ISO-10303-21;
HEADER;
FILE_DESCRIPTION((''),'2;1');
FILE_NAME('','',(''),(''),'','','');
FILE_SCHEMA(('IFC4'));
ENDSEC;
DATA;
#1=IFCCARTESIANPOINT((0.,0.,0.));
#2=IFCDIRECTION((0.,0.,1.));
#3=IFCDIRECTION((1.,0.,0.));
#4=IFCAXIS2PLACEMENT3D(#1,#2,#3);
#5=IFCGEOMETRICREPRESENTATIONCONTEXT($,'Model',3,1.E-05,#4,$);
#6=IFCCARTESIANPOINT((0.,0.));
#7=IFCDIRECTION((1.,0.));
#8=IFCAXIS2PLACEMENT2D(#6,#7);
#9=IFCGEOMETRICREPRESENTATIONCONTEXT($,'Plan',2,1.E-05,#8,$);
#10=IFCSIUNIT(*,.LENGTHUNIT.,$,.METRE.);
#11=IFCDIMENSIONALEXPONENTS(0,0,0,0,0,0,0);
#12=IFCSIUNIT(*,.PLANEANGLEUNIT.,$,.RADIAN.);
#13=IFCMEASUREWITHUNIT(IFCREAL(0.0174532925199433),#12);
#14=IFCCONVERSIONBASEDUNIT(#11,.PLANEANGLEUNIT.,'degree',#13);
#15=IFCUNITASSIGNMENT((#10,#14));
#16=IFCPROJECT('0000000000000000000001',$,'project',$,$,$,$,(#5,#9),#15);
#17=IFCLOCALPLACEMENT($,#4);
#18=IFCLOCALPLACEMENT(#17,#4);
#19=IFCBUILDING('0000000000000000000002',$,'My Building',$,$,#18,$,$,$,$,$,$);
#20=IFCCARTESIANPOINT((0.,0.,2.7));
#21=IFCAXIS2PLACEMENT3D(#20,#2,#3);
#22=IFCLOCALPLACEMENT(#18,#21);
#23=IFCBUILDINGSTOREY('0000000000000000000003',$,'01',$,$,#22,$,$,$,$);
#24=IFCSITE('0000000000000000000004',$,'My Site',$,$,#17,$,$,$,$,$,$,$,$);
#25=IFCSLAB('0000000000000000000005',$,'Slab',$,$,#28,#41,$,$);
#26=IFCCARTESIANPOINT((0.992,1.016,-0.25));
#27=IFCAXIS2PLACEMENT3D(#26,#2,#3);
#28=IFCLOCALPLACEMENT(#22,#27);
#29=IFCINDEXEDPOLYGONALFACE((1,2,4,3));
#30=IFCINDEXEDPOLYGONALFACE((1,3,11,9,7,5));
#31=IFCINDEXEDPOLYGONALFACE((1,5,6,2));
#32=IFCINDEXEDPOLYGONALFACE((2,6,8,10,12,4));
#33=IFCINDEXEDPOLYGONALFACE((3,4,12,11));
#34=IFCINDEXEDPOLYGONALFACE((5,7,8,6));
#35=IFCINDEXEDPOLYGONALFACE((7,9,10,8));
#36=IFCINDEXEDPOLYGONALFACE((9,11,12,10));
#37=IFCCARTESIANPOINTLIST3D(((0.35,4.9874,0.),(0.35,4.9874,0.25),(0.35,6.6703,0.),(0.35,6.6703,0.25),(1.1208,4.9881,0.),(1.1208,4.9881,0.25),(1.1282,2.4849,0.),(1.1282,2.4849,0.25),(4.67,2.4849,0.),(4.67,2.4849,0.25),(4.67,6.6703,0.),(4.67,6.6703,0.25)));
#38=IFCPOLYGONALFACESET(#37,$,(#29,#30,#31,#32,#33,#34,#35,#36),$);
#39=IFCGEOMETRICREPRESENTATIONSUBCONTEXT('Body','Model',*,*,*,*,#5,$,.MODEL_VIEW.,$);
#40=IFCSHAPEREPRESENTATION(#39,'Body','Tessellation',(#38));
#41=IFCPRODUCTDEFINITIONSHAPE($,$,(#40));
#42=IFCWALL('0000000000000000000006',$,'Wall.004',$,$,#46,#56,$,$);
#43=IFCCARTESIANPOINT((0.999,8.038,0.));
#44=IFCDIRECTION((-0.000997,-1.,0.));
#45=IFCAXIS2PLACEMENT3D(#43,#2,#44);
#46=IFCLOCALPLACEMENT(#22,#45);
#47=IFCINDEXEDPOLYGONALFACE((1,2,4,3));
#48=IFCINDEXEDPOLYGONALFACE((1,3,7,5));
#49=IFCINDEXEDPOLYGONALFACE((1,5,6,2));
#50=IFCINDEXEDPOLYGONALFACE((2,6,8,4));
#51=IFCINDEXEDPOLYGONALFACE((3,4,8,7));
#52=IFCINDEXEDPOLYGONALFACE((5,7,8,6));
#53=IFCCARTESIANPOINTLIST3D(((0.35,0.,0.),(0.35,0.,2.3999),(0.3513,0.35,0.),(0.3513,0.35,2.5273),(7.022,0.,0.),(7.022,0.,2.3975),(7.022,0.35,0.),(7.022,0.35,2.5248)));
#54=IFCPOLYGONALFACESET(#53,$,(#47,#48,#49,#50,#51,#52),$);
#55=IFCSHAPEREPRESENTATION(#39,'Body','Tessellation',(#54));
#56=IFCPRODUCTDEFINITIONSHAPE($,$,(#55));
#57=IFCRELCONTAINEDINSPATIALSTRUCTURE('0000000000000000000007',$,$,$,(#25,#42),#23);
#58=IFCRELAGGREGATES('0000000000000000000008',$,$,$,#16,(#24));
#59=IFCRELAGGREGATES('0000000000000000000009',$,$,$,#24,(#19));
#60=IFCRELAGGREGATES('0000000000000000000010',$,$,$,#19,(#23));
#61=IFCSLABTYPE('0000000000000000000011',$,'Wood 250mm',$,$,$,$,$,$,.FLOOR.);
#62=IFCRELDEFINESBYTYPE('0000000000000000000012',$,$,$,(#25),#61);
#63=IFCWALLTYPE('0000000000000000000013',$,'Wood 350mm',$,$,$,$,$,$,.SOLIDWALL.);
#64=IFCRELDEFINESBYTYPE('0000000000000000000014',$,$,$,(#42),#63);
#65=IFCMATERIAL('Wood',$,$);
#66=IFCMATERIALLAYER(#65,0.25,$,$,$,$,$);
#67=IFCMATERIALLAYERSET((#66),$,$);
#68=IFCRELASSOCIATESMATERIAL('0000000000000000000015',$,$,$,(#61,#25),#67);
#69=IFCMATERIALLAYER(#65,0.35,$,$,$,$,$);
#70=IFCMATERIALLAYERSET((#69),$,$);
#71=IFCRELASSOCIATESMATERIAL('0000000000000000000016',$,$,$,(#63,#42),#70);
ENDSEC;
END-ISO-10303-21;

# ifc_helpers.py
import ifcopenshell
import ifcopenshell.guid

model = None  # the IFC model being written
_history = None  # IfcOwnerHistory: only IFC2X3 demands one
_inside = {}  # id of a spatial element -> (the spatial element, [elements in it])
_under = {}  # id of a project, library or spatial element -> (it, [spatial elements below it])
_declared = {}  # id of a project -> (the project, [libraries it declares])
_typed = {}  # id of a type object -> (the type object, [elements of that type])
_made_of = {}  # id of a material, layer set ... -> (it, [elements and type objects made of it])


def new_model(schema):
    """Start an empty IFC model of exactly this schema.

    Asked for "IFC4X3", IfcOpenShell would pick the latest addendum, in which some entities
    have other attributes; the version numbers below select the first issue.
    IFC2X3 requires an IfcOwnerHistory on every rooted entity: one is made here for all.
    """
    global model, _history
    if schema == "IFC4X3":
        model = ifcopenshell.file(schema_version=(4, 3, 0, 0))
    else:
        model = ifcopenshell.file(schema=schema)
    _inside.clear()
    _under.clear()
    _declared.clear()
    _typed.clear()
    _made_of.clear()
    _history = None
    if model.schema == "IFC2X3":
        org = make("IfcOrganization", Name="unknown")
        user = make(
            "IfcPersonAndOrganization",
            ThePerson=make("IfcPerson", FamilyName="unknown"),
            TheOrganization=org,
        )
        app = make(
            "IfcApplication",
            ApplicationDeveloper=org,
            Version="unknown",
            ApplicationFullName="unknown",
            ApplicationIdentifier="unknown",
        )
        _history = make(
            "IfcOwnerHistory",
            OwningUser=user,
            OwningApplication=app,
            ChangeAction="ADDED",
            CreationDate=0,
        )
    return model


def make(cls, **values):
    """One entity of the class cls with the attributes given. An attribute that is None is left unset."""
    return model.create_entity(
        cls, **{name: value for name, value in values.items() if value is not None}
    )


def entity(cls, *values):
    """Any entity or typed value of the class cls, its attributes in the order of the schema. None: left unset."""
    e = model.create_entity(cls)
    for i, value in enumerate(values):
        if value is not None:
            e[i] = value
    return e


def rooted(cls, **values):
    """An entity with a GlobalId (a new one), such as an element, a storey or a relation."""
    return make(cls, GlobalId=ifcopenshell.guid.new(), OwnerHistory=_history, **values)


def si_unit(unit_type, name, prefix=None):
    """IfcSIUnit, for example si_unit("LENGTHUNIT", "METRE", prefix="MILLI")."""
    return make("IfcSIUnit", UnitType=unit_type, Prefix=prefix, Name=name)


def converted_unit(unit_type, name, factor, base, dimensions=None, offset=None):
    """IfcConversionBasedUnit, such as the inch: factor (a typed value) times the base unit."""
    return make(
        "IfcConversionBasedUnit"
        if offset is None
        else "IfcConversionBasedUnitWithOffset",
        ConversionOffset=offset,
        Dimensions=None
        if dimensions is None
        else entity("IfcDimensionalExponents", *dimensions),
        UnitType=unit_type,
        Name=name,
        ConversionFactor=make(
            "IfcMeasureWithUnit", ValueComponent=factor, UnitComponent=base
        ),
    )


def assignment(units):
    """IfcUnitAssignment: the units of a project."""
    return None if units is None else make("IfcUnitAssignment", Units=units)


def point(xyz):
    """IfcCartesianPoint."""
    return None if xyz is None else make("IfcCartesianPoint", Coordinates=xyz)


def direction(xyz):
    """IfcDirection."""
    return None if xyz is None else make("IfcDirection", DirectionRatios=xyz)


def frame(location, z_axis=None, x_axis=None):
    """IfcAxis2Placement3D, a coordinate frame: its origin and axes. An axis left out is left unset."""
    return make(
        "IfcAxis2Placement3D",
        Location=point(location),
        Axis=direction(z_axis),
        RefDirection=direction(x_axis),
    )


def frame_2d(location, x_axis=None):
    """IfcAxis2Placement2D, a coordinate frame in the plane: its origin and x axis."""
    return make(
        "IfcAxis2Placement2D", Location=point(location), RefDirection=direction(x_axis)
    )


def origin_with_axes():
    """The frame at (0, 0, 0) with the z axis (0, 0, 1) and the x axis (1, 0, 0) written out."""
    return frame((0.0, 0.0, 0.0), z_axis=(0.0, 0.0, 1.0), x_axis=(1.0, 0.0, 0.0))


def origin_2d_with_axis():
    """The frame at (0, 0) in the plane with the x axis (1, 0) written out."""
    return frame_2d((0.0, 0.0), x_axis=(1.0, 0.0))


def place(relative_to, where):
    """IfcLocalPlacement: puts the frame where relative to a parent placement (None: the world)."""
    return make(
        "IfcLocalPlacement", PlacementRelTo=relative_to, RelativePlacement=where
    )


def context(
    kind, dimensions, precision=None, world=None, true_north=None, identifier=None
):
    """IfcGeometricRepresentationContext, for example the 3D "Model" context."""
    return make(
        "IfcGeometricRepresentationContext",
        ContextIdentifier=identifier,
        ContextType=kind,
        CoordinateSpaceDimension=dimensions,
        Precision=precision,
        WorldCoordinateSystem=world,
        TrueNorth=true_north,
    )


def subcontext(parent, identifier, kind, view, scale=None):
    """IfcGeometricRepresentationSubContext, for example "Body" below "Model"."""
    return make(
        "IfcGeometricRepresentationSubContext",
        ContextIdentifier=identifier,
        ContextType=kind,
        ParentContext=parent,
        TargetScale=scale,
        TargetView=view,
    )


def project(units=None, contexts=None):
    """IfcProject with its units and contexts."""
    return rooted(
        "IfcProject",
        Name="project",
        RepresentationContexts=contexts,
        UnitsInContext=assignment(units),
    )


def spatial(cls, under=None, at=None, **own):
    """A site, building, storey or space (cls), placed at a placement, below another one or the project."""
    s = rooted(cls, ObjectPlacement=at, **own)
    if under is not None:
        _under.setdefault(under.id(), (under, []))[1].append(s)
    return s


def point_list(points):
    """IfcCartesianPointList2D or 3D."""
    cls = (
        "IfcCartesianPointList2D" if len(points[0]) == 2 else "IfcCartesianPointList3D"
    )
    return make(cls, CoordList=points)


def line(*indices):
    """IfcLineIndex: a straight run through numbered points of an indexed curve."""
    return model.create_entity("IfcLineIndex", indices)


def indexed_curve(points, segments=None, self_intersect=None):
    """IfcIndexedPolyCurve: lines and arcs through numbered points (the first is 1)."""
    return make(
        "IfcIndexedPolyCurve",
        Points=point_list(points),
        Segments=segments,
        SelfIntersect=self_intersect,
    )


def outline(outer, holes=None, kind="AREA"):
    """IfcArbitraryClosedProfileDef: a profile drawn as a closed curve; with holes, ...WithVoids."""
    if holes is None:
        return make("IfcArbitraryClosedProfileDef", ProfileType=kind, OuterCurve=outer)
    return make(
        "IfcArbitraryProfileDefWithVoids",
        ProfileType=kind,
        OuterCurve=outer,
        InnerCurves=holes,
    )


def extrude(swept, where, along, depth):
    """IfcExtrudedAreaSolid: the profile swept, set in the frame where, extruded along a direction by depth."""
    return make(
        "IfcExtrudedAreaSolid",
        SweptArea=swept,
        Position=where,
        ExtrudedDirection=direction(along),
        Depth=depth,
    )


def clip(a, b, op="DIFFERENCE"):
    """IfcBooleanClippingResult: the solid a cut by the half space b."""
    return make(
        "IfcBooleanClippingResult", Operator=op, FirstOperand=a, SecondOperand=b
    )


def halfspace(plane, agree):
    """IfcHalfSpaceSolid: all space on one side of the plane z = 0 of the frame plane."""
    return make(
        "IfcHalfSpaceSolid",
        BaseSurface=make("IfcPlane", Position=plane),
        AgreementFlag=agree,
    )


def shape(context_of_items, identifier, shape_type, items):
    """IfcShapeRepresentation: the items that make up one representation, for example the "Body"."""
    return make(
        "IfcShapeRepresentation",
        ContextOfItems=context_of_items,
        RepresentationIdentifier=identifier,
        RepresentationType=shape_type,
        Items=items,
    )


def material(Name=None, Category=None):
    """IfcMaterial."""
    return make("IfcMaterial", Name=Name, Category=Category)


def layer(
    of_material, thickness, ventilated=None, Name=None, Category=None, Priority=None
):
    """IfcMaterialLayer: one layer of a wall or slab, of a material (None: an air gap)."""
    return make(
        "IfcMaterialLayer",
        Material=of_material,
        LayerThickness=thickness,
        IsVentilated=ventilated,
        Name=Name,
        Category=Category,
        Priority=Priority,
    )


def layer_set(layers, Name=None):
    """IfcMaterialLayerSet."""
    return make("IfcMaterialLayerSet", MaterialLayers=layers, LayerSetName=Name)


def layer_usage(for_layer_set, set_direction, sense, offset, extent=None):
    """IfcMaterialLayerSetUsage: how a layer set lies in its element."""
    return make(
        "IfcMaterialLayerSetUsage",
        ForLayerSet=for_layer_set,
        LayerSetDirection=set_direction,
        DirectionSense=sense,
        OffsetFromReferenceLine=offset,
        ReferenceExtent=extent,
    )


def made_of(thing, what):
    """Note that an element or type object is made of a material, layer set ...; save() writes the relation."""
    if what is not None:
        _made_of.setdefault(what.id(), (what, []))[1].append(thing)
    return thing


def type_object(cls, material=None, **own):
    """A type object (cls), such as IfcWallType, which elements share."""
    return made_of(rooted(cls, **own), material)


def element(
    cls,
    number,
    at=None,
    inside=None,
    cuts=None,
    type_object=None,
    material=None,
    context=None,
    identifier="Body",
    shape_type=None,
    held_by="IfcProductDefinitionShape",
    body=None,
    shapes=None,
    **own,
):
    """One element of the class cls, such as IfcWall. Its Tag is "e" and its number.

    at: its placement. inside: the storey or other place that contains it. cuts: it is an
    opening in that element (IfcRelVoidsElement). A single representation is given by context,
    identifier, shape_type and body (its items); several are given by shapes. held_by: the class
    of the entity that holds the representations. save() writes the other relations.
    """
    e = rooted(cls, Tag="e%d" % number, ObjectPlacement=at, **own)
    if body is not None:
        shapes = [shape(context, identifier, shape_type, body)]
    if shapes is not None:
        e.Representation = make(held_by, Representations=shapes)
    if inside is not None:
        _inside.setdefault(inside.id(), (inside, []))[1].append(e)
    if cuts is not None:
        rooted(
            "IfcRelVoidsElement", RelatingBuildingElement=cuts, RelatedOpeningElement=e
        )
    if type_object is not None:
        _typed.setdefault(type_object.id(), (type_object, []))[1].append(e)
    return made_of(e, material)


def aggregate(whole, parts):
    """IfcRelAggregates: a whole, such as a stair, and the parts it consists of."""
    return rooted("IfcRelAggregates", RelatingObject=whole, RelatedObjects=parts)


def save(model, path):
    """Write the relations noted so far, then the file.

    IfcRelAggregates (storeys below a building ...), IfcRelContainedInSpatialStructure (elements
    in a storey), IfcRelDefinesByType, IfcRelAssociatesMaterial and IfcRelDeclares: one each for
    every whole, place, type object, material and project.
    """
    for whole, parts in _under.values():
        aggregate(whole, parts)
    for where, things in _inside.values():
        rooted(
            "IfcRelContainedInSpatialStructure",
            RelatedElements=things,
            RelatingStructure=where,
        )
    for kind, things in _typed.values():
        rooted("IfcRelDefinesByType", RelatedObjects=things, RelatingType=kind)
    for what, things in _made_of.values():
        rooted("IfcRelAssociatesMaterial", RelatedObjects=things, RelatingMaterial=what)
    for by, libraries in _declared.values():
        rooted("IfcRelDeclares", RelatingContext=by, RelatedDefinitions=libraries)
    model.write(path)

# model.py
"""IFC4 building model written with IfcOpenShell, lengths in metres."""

from ifc_helpers import new_model, entity, si_unit, converted_unit, frame, origin_with_axes, origin_2d_with_axis, place, context, subcontext, project, spatial, line, indexed_curve, outline, extrude, clip, halfspace, material, layer, layer_set, layer_usage, type_object, element, save


model = new_model("IFC4")

# Units and contexts
model_context = context("Model", 3, precision=1e-05, world=origin_with_axes())
plan_context = context("Plan", 2, precision=1e-05, world=origin_2d_with_axis())
body_context = subcontext(model_context, "Body", "Model", "MODEL_VIEW")
ifc_project = project(units=[si_unit("LENGTHUNIT", "METRE"), converted_unit("PLANEANGLEUNIT", "degree", entity("IfcReal", 0.0174532925199433), si_unit("PLANEANGLEUNIT", "RADIAN"), dimensions=[0, 0, 0, 0, 0, 0, 0])], contexts=[model_context, plan_context])

# Site, building, storey
site_placement = place(None, origin_with_axes())
site = spatial("IfcSite", under=ifc_project, at=site_placement, Name="My Site")
building_placement = place(site_placement, origin_with_axes())
building = spatial("IfcBuilding", under=site, at=building_placement, Name="My Building")
storey_placement = place(building_placement, frame((0.0, 0.0, 2.7), z_axis=(0.0, 0.0, 1.0), x_axis=(1.0, 0.0, 0.0)))
storey = spatial("IfcBuildingStorey", under=building, at=storey_placement, Name="01")

# Slab
ifc_material = material(Name="Wood")
ifc_layer_1 = layer(ifc_material, 0.25)
ifc_layer_set_1 = layer_set([ifc_layer_1])
ifc_layer_usage_1 = layer_usage(ifc_layer_set_1, "AXIS3", "POSITIVE", 0.0)
slab_type = type_object("IfcSlabType", Name="Wood 250mm", PredefinedType="FLOOR", material=ifc_layer_set_1)
slab_placement = place(storey_placement, frame((0.992, 1.016, -0.25), z_axis=(0.0, 0.0, 1.0), x_axis=(1.0, 0.0, 0.0)))
element("IfcSlab", 1, at=slab_placement, inside=storey, type_object=slab_type, material=ifc_layer_usage_1, Name="Slab", context=body_context, shape_type="SweptSolid", body=[
    extrude(outline(indexed_curve([(1.1208, 4.9881), (4.67, 2.4849), (4.67, 6.6703), (0.35, 6.6703), (1.1282, 2.4849), (0.35, 4.9874)], segments=[line(5, 2), line(2, 3), line(3, 4), line(4, 6), line(6, 1), line(1, 5)], self_intersect=False)), None, (0.0, 0.0, 1.0), 0.25),
])

# Wall
ifc_layer_2 = layer(ifc_material, 0.35)
ifc_layer_set_2 = layer_set([ifc_layer_2])
ifc_layer_usage_2 = layer_usage(ifc_layer_set_2, "AXIS2", "POSITIVE", 0.0)
wall_type = type_object("IfcWallType", Name="Wood 350mm", PredefinedType="SOLIDWALL", material=ifc_layer_set_2)
wall_1_placement = place(storey_placement, frame((0.999, 8.038, 0.0), z_axis=(0.0, 0.0, 1.0), x_axis=(-0.000997, -1.0, 0.0)))
element("IfcWall", 2, at=wall_1_placement, inside=storey, type_object=wall_type, material=ifc_layer_usage_2, Name="Wall.004", context=body_context, shape_type="Clipping", body=[
    clip(clip(extrude(outline(indexed_curve([(0.0, 0.0), (0.0, 0.35), (7.022, 0.35), (7.022, 0.0), (0.0, 0.0)], self_intersect=False)), origin_with_axes(), (0.0, 0.0, 1.0), 2.7), halfspace(frame((7.022, 0.007, 2.4), z_axis=(0.000341, -0.34202, 0.939693), x_axis=(-0.000937, 0.939692, 0.34202)), False)), halfspace(frame((0.35, 0.0, -2.7), z_axis=(-0.884542, 0.003354, 0.0), x_axis=(0.003792, 0.999993, 0.0)), False)),
])

save(model, "model.ifc")
